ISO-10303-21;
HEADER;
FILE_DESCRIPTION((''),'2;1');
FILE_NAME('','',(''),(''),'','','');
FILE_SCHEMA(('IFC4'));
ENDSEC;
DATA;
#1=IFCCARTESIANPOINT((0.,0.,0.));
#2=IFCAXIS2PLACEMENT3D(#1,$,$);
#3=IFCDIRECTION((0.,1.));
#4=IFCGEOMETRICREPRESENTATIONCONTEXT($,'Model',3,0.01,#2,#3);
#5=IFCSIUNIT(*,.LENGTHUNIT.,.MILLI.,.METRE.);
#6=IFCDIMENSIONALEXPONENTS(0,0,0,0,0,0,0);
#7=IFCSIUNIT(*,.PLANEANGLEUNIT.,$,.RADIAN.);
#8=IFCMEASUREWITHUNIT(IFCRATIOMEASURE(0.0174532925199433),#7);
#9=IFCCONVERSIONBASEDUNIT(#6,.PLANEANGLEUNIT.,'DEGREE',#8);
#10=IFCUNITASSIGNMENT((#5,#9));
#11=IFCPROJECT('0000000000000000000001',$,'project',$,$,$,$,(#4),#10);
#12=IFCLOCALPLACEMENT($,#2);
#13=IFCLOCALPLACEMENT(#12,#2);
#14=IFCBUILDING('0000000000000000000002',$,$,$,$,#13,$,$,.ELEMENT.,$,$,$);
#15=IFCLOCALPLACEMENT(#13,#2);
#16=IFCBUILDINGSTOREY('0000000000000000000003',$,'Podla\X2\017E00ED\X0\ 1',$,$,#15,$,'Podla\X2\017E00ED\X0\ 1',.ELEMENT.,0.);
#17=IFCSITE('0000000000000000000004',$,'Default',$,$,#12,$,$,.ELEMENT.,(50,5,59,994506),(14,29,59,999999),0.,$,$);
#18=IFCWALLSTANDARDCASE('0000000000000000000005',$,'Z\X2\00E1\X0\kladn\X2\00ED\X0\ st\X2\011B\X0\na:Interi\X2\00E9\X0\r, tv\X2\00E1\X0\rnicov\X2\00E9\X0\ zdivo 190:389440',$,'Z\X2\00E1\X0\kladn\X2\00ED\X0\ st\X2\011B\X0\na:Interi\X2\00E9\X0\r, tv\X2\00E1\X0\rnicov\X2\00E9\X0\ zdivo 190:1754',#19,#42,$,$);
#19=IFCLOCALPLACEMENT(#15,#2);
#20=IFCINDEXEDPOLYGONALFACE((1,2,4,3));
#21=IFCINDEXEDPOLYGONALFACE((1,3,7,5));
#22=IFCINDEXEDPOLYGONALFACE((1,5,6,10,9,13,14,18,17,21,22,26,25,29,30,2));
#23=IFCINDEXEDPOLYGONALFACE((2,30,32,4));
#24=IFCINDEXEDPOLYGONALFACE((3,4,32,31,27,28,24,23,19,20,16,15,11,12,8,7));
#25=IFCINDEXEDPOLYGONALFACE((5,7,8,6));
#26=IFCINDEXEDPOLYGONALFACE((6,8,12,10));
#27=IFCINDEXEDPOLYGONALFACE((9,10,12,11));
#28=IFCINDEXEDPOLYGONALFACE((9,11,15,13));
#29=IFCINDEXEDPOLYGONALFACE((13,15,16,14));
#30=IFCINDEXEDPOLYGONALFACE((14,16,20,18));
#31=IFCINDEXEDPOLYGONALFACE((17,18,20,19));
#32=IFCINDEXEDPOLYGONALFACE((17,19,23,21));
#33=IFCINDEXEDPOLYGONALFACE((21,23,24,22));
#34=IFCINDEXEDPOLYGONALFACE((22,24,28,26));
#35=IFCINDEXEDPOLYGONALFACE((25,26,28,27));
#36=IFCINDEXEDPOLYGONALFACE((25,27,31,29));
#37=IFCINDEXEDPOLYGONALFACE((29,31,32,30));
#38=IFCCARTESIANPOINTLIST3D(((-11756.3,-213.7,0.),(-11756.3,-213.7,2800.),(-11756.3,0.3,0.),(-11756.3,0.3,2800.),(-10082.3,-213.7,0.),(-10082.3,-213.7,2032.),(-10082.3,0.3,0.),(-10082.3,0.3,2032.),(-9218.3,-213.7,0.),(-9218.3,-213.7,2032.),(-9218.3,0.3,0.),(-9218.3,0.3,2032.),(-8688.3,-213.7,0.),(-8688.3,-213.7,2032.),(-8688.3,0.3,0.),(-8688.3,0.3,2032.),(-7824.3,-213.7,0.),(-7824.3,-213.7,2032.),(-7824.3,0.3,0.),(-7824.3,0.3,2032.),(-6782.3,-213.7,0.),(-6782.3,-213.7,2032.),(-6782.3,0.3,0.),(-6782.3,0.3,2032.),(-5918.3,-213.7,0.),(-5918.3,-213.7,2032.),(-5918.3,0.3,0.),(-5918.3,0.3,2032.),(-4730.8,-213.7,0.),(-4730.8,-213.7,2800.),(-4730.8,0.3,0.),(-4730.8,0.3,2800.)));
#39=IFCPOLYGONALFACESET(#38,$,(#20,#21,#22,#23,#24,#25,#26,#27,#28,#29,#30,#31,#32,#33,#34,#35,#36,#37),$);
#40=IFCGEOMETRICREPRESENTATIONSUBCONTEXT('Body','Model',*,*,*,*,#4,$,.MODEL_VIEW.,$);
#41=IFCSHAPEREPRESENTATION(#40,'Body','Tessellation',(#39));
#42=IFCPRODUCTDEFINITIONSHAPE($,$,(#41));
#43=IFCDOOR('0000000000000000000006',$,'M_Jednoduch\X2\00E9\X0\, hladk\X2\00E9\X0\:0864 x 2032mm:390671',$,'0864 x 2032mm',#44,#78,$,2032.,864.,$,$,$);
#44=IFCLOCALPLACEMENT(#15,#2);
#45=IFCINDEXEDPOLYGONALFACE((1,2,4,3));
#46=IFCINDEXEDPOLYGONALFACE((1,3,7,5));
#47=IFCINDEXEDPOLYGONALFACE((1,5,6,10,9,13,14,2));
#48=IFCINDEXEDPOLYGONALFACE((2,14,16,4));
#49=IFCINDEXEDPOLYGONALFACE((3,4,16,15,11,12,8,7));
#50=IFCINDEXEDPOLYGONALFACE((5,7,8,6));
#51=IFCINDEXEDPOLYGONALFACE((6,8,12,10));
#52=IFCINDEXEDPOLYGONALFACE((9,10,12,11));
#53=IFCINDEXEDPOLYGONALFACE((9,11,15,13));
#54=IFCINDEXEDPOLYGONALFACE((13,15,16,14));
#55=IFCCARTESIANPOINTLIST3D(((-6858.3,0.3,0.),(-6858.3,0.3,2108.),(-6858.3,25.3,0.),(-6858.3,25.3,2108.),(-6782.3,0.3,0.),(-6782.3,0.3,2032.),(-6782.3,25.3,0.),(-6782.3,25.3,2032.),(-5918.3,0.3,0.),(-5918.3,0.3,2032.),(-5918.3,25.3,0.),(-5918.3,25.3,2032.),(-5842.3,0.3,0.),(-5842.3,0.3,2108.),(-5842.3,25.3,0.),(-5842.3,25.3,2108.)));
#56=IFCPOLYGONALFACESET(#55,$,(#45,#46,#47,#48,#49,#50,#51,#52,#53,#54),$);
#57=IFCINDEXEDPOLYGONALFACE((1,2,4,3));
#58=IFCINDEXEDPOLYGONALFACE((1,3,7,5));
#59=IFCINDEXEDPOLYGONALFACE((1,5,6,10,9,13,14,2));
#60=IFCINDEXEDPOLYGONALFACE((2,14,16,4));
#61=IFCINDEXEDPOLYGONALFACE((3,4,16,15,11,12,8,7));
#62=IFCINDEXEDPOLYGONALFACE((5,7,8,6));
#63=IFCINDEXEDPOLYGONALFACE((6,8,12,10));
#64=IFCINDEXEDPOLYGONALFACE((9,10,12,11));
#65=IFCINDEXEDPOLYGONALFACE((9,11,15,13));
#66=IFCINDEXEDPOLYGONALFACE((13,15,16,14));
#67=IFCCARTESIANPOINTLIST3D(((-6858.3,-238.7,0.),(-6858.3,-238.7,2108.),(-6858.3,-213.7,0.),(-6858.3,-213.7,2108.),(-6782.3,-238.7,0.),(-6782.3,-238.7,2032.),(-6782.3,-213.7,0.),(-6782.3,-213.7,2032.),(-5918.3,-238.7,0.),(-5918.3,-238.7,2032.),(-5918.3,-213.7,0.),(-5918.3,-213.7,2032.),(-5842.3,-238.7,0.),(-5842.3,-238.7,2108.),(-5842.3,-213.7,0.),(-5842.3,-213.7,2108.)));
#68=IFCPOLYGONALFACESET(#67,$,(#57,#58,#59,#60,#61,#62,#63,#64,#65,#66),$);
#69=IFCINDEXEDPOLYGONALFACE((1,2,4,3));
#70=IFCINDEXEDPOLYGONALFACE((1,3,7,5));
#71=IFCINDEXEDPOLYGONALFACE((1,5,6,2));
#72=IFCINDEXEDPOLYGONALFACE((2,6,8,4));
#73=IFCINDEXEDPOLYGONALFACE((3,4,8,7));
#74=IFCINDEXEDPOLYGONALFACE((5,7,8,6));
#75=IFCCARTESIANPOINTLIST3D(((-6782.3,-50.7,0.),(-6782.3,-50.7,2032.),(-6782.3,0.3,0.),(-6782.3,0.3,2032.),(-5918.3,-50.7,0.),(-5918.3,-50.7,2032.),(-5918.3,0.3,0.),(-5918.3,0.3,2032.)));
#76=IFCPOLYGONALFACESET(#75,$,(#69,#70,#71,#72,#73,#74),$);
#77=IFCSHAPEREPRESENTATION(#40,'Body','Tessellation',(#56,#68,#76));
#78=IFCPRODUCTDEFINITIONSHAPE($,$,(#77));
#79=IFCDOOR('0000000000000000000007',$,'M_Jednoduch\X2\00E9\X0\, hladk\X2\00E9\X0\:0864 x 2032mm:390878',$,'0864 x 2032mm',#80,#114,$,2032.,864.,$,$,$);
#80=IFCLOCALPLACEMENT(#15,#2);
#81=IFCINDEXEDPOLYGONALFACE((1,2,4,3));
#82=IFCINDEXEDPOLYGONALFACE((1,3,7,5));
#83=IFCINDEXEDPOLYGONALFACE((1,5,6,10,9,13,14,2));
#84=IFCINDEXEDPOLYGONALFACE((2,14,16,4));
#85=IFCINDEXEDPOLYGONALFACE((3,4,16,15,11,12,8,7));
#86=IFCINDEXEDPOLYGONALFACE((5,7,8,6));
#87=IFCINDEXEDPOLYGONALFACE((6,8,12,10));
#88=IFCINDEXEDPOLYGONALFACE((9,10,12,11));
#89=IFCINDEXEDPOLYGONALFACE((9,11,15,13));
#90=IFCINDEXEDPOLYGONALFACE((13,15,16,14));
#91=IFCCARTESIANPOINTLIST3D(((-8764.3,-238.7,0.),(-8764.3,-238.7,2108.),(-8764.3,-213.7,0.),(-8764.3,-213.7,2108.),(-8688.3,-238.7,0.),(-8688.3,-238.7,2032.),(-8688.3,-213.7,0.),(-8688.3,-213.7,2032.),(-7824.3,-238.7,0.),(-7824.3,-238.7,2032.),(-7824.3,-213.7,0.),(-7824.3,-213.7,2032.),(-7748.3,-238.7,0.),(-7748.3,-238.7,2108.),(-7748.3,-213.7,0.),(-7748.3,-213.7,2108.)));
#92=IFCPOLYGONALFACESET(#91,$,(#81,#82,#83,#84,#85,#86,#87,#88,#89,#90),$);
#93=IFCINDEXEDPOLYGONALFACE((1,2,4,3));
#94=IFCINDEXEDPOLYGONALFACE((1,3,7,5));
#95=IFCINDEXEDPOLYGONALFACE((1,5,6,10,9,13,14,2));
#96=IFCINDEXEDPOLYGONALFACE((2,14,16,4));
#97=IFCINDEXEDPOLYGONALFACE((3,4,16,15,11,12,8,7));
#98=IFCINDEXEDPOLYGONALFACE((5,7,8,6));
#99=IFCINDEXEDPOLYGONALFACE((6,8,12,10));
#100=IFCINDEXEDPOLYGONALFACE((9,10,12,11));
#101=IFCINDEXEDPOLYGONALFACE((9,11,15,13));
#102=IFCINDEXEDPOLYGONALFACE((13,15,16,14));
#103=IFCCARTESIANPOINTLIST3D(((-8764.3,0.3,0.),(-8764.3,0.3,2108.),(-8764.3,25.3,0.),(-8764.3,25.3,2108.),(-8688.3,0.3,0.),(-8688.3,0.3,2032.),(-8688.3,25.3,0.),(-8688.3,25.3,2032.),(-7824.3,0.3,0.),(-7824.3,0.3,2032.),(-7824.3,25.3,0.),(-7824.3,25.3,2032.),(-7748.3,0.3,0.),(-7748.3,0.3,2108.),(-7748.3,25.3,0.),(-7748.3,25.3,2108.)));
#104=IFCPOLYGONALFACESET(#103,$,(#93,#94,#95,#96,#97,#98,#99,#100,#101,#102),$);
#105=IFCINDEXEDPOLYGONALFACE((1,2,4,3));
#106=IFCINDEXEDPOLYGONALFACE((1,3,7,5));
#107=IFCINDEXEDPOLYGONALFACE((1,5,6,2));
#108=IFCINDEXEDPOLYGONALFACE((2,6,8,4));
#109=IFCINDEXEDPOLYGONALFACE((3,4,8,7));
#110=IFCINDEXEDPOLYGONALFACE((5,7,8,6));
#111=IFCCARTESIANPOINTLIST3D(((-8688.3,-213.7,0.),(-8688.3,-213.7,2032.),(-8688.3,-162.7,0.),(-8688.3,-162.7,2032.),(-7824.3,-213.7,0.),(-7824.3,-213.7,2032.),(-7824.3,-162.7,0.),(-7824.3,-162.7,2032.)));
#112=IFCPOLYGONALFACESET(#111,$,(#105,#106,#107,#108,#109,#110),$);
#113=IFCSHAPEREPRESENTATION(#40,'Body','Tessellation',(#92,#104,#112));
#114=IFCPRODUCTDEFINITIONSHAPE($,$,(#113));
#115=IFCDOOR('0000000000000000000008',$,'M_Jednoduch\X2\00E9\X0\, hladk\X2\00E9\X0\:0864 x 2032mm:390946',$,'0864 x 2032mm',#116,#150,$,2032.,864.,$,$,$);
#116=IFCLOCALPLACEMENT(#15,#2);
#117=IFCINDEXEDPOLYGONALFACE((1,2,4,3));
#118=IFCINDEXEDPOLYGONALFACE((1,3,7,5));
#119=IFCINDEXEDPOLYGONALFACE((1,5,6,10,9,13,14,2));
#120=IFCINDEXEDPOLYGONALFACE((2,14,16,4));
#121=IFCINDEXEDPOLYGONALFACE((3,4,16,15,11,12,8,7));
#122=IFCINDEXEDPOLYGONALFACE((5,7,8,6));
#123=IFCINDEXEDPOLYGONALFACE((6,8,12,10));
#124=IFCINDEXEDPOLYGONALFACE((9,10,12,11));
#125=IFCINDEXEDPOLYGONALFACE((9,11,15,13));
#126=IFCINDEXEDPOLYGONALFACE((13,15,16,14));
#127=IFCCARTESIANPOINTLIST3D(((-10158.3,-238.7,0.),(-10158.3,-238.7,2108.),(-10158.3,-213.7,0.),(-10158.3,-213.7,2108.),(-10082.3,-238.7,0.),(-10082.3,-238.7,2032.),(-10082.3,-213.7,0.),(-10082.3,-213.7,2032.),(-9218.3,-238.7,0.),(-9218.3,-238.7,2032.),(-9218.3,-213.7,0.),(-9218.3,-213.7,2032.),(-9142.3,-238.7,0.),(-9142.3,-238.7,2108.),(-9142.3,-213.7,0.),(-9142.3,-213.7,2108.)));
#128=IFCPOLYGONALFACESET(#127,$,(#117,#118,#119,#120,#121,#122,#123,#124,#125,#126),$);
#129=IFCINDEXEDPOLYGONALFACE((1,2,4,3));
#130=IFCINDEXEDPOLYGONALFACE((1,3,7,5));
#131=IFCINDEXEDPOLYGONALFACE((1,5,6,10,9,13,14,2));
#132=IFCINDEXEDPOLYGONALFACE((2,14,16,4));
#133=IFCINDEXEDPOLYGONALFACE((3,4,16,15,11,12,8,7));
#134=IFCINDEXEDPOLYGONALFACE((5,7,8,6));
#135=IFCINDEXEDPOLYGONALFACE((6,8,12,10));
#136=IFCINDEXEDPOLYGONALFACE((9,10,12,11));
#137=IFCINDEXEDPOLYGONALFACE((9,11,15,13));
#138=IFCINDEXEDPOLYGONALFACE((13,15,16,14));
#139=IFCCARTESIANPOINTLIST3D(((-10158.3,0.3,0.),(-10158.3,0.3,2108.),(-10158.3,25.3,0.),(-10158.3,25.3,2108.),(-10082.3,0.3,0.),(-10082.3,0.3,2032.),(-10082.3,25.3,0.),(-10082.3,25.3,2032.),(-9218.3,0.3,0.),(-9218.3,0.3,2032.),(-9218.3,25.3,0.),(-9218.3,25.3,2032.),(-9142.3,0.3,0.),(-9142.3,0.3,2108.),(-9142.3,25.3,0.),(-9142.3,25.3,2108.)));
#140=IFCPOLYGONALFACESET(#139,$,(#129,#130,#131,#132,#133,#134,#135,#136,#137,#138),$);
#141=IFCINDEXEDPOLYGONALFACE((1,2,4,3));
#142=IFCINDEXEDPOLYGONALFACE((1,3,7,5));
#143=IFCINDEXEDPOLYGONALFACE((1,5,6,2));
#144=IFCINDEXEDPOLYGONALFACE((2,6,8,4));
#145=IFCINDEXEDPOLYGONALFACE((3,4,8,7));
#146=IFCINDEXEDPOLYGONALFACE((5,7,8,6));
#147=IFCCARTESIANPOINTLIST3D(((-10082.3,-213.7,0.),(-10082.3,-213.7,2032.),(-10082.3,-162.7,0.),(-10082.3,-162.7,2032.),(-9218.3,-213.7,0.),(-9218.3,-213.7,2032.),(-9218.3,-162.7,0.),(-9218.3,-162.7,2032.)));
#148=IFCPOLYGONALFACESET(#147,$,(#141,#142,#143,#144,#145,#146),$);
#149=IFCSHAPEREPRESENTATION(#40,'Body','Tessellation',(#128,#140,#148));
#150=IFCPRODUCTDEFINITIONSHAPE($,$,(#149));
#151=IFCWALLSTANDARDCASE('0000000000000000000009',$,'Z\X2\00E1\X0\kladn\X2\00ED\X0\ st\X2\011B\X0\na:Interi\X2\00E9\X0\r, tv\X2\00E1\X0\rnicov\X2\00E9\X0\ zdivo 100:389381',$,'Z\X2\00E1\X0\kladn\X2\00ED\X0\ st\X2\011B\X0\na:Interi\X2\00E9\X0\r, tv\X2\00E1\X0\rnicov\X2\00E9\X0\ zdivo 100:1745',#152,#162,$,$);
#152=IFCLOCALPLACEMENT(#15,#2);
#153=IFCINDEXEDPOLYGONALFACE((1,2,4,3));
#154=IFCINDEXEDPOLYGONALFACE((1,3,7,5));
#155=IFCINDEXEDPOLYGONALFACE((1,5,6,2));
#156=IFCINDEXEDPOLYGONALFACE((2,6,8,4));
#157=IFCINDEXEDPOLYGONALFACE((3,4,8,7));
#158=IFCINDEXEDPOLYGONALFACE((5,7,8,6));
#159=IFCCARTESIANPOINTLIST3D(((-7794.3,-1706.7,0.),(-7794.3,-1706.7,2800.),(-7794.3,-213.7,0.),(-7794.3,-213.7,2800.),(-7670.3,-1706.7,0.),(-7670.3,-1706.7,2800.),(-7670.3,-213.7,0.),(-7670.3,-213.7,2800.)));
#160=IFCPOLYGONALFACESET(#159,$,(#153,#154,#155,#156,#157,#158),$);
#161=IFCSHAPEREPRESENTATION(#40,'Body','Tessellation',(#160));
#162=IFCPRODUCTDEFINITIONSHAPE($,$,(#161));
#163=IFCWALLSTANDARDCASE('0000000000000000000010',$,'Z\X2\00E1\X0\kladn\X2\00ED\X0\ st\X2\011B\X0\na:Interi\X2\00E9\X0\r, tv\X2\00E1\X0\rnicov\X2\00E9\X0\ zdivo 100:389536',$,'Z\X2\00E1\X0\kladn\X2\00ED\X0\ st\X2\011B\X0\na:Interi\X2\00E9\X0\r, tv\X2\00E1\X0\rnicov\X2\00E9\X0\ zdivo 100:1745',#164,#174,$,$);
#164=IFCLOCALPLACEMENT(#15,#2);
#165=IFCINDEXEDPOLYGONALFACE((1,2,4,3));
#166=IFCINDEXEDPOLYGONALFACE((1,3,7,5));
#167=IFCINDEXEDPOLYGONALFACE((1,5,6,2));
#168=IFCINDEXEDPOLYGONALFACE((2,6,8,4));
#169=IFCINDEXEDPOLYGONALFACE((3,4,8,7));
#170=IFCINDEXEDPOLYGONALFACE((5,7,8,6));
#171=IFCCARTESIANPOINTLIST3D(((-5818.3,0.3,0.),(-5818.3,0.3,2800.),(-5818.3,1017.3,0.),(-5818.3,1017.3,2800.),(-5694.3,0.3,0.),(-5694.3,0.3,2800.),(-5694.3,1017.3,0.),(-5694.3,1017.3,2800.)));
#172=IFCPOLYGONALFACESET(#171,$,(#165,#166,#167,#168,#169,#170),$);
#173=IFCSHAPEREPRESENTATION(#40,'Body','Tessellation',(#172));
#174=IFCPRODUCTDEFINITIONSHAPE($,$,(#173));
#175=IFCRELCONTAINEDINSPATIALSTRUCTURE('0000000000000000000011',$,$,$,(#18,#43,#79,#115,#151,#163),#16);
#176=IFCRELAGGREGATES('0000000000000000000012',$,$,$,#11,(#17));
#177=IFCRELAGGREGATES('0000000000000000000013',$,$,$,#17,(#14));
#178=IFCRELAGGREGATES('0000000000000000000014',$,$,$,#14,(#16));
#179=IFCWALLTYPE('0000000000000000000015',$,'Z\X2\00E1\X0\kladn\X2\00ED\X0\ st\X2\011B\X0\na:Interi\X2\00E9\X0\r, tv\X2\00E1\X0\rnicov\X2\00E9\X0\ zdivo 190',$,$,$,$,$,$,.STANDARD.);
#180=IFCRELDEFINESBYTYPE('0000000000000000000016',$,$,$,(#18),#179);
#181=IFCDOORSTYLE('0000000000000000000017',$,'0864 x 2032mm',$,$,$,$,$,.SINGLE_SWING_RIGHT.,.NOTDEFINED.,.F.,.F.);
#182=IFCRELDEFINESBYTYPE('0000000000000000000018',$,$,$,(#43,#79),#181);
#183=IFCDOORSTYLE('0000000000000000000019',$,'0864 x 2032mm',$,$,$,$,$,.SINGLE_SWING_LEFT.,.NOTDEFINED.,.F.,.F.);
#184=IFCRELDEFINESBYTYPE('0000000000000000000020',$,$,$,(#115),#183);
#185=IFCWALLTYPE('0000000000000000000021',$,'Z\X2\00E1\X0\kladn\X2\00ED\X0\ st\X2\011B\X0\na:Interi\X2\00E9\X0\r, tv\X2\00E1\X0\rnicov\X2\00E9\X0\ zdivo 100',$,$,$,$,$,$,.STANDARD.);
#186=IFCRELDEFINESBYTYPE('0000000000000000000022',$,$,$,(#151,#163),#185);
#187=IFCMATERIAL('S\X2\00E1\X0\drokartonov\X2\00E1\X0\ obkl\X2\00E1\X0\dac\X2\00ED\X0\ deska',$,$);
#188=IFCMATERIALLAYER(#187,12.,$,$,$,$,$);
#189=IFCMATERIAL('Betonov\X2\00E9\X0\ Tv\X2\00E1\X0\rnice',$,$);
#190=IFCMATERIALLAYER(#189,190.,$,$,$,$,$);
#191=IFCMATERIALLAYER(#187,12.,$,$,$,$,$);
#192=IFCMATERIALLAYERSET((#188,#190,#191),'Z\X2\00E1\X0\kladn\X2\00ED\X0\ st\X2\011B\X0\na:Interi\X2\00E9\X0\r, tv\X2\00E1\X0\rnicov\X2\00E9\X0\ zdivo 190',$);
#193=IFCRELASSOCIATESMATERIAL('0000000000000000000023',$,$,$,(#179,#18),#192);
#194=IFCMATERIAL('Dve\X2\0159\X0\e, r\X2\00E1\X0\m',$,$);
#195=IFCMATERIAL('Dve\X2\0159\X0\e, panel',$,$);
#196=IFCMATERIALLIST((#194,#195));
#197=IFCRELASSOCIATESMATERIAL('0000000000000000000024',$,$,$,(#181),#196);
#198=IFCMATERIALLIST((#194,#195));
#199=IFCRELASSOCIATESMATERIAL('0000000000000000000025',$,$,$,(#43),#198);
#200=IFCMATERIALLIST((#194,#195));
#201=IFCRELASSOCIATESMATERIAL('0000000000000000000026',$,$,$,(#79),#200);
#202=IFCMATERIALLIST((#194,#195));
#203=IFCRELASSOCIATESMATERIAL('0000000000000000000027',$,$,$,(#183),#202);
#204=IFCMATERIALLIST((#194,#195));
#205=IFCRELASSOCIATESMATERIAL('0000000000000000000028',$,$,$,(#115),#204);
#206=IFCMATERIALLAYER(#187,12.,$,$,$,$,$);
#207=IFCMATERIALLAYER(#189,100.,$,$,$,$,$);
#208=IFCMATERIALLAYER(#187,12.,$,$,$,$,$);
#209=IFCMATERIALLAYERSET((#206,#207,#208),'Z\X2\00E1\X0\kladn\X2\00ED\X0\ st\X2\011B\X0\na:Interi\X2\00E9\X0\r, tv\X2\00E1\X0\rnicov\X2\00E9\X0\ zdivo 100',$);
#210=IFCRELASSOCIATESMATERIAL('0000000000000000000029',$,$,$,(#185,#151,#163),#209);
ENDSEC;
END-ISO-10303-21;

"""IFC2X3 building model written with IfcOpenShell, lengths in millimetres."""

from ifc_helpers import new_model, entity, si_unit, converted_unit, direction, frame, frame_2d, origin, place, context, subcontext, project, spatial, polyline, rectangle, outline, extrude, source, transform, mapped, material, material_list, layer, layer_set, layer_usage, type_object, type_shapes, element, fill, save


model = new_model("IFC2X3")

# Units and contexts
model_context = context("Model", 3, precision=0.01, world=origin(), true_north=direction((0.0, 1.0)))
body_context = subcontext(model_context, "Body", "Model", "MODEL_VIEW")
ifc_project = project(units=[si_unit("LENGTHUNIT", "METRE", prefix="MILLI"), converted_unit("PLANEANGLEUNIT", "DEGREE", entity("IfcRatioMeasure", 0.0174532925199433), si_unit("PLANEANGLEUNIT", "RADIAN"), dimensions=[0, 0, 0, 0, 0, 0, 0])], contexts=[model_context])

# Site, building, storey
site_placement = place(None, origin())
site = spatial("IfcSite", under=ifc_project, at=site_placement, Name="Default", CompositionType="ELEMENT", RefLatitude=(50, 5, 59, 994506), RefLongitude=(14, 29, 59, 999999), RefElevation=0.0)
building_placement = place(site_placement, origin())
building = spatial("IfcBuilding", under=site, at=building_placement, CompositionType="ELEMENT")
storey_placement = place(building_placement, origin())
storey = spatial("IfcBuildingStorey", under=building, at=storey_placement, Name="Podlaží 1", LongName="Podlaží 1", CompositionType="ELEMENT", Elevation=0.0)

# Shared definitions
ifc_material_1 = material(Name="Betonové Tvárnice")
ifc_material_2 = material(Name="Sádrokartonová obkládací deska")

# Wall, openings, doors
ifc_layer_1 = layer(ifc_material_2, 12.0)
ifc_layer_2 = layer(ifc_material_1, 190.0)
ifc_layer_3 = layer(ifc_material_2, 12.0)
ifc_layer_set_1 = layer_set([ifc_layer_1, ifc_layer_2, ifc_layer_3], Name="Základní stěna:Interiér, tvárnicové zdivo 190")
ifc_layer_usage_1 = layer_usage(ifc_layer_set_1, "AXIS2", "NEGATIVE", 107.0)
wall_type_1 = type_object("IfcWallType", Name="Základní stěna:Interiér, tvárnicové zdivo 190", PredefinedType="STANDARD", material=ifc_layer_set_1)
wall_1_placement = place(storey_placement, frame((-11756.3, -106.7, 0.0)))
wall_1 = element("IfcWallStandardCase", 1, at=wall_1_placement, inside=storey, type_object=wall_type_1, material=ifc_layer_usage_1, Name="Základní stěna:Interiér, tvárnicové zdivo 190:389440", ObjectType="Základní stěna:Interiér, tvárnicové zdivo 190:1754", context=body_context, shape_type="SweptSolid", body=[
    extrude(rectangle(XDim=7025.5, YDim=214.0, at=frame_2d((3512.8, 0.0), x_axis=(-1.0, 0.0))), origin(), (0.0, 0.0, 1.0), 2800.0),
])
opening_1_placement = place(wall_1_placement, frame((4974.0, -107.0, 0.0)))
opening_1 = element("IfcOpeningElement", 2, at=opening_1_placement, cuts=wall_1, ObjectType="Opening", context=body_context, shape_type="SweptSolid", body=[
    extrude(rectangle(XDim=864.0, YDim=2032.0, at=frame_2d((1016.0, 432.0), x_axis=(0.0, 1.0))), frame((0.0, 0.0, 0.0), z_axis=(0.0, 1.0, 0.0), x_axis=(0.0, 0.0, 1.0)), (0.0, 0.0, 1.0), 214.0),
])
opening_2_placement = place(wall_1_placement, frame((3932.0, 107.0, 0.0)))
opening_2 = element("IfcOpeningElement", 3, at=opening_2_placement, cuts=wall_1, ObjectType="Opening", context=body_context, shape_type="SweptSolid", body=[
    extrude(rectangle(XDim=864.0, YDim=2032.0, at=frame_2d((1016.0, 432.0), x_axis=(0.0, 1.0))), frame((0.0, 0.0, 0.0), z_axis=(0.0, -1.0, 0.0), x_axis=(0.0, 0.0, 1.0)), (0.0, 0.0, 1.0), 214.0),
])
opening_3_placement = place(wall_1_placement, frame((2538.0, 107.0, 0.0)))
opening_3 = element("IfcOpeningElement", 4, at=opening_3_placement, cuts=wall_1, ObjectType="Opening", context=body_context, shape_type="SweptSolid", body=[
    extrude(rectangle(XDim=864.0, YDim=2032.0, at=frame_2d((1016.0, 432.0), x_axis=(0.0, -1.0))), frame((0.0, 0.0, 0.0), z_axis=(0.0, -1.0, 0.0), x_axis=(0.0, 0.0, 1.0)), (0.0, 0.0, 1.0), 214.0),
])
ifc_material_3 = material(Name="Dveře, rám")
ifc_material_4 = material(Name="Dveře, panel")
ifc_material_list_1 = material_list([ifc_material_3, ifc_material_4])
ifc_material_list_2 = material_list([ifc_material_3, ifc_material_4])
door_style_1 = type_object("IfcDoorStyle", Name="0864 x 2032mm", ConstructionType="NOTDEFINED", OperationType="SINGLE_SWING_RIGHT", ParameterTakesPrecedence=False, Sizeable=False, material=ifc_material_list_2)
shared_shape_1 = source(origin(), body_context, "Body", "SweptSolid", [
    extrude(outline(polyline([(-508.0, -1073.0), (508.0, -1073.0), (508.0, 1035.0), (432.0, 1035.0), (432.0, -997.0), (-432.0, -997.0), (-432.0, 1035.0), (-508.0, 1035.0), (-508.0, -1073.0)])), frame((432.0, 214.0, 1035.0), z_axis=(0.0, 1.0, 0.0), x_axis=(1.0, 0.0, 0.0)), (0.0, 0.0, 1.0), 25.0),
    extrude(outline(polyline([(-1073.0, -508.0), (1035.0, -508.0), (1035.0, -432.0), (-997.0, -432.0), (-997.0, 432.0), (1035.0, 432.0), (1035.0, 508.0), (-1073.0, 508.0), (-1073.0, -508.0)])), frame((432.0, -25.0, 1035.0), z_axis=(0.0, 1.0, 0.0), x_axis=(0.0, 0.0, -1.0)), (0.0, 0.0, 1.0), 25.0),
    extrude(rectangle(XDim=51.0, YDim=864.0, at=frame_2d((0.0, 0.0), x_axis=(1.0, 0.0))), frame((432.0, 188.5, 0.0), z_axis=(0.0, 0.0, 1.0), x_axis=(0.0, 1.0, 0.0)), (0.0, 0.0, 1.0), 2032.0),
])
type_shapes(door_style_1, [shared_shape_1])
door_1_placement = place(opening_1_placement, origin())
door_1 = element("IfcDoor", 5, at=door_1_placement, inside=storey, type_object=door_style_1, material=ifc_material_list_1, Name="M_Jednoduché, hladké:0864 x 2032mm:390671", ObjectType="0864 x 2032mm", OverallHeight=2032.0, OverallWidth=864.0, context=body_context, shape_type="MappedRepresentation", body=[
    mapped(shared_shape_1, transform((0.0, 0.0, 0.0), scale=1.0)),
])
fill(opening_1, door_1)
ifc_material_list_3 = material_list([ifc_material_3, ifc_material_4])
door_2_placement = place(opening_2_placement, frame((0.0, 0.0, 0.0), z_axis=(0.0, 0.0, 1.0), x_axis=(-1.0, 0.0, 0.0)))
door_2 = element("IfcDoor", 6, at=door_2_placement, inside=storey, type_object=door_style_1, material=ifc_material_list_3, Name="M_Jednoduché, hladké:0864 x 2032mm:390878", ObjectType="0864 x 2032mm", OverallHeight=2032.0, OverallWidth=864.0, context=body_context, shape_type="MappedRepresentation", body=[
    mapped(shared_shape_1, transform((0.0, 0.0, 0.0), scale=1.0)),
])
fill(opening_2, door_2)
ifc_material_list_4 = material_list([ifc_material_3, ifc_material_4])
ifc_material_list_5 = material_list([ifc_material_3, ifc_material_4])
door_style_2 = type_object("IfcDoorStyle", Name="0864 x 2032mm", ConstructionType="NOTDEFINED", OperationType="SINGLE_SWING_LEFT", ParameterTakesPrecedence=False, Sizeable=False, material=ifc_material_list_5)
shared_shape_2 = source(origin(), body_context, "Body", "SweptSolid", [
    extrude(outline(polyline([(-508.0, -1073.0), (508.0, -1073.0), (508.0, 1035.0), (432.0, 1035.0), (432.0, -997.0), (-432.0, -997.0), (-432.0, 1035.0), (-508.0, 1035.0), (-508.0, -1073.0)])), frame((432.0, 239.0, 1035.0), z_axis=(0.0, -1.0, 0.0), x_axis=(-1.0, 0.0, 0.0)), (0.0, 0.0, 1.0), 25.0),
    extrude(outline(polyline([(-1073.0, -508.0), (1035.0, -508.0), (1035.0, -432.0), (-997.0, -432.0), (-997.0, 432.0), (1035.0, 432.0), (1035.0, 508.0), (-1073.0, 508.0), (-1073.0, -508.0)])), frame((432.0, 0.0, 1035.0), z_axis=(0.0, -1.0, 0.0), x_axis=(0.0, 0.0, -1.0)), (0.0, 0.0, 1.0), 25.0),
    extrude(rectangle(XDim=864.0, YDim=51.0, at=frame_2d((0.0, 0.0), x_axis=(1.0, 0.0))), frame((432.0, 188.5, 0.0)), (0.0, 0.0, 1.0), 2032.0),
])
type_shapes(door_style_2, [shared_shape_2])
door_3_placement = place(opening_3_placement, frame((0.0, 0.0, 0.0), z_axis=(0.0, 0.0, 1.0), x_axis=(-1.0, 0.0, 0.0)))
door_3 = element("IfcDoor", 7, at=door_3_placement, inside=storey, type_object=door_style_2, material=ifc_material_list_4, Name="M_Jednoduché, hladké:0864 x 2032mm:390946", ObjectType="0864 x 2032mm", OverallHeight=2032.0, OverallWidth=864.0, context=body_context, shape_type="MappedRepresentation", body=[
    mapped(shared_shape_2, transform((0.0, 0.0, 0.0), scale=1.0)),
])
fill(opening_3, door_3)

# Walls
ifc_layer_4 = layer(ifc_material_2, 12.0)
ifc_layer_5 = layer(ifc_material_1, 100.0)
ifc_layer_6 = layer(ifc_material_2, 12.0)
ifc_layer_set_2 = layer_set([ifc_layer_4, ifc_layer_5, ifc_layer_6], Name="Základní stěna:Interiér, tvárnicové zdivo 100")
ifc_layer_usage_2 = layer_usage(ifc_layer_set_2, "AXIS2", "NEGATIVE", 62.0)
wall_type_2 = type_object("IfcWallType", Name="Základní stěna:Interiér, tvárnicové zdivo 100", PredefinedType="STANDARD", material=ifc_layer_set_2)
wall_2_placement = place(storey_placement, frame((-7732.3, -1706.7, 0.0), z_axis=(0.0, 0.0, 1.0), x_axis=(0.0, 1.0, 0.0)))
element("IfcWallStandardCase", 8, at=wall_2_placement, inside=storey, type_object=wall_type_2, material=ifc_layer_usage_2, Name="Základní stěna:Interiér, tvárnicové zdivo 100:389381", ObjectType="Základní stěna:Interiér, tvárnicové zdivo 100:1745", context=body_context, shape_type="SweptSolid", body=[
    extrude(rectangle(XDim=1493.0, YDim=124.0, at=frame_2d((746.5, 0.0), x_axis=(-1.0, 0.0))), origin(), (0.0, 0.0, 1.0), 2800.0),
])
ifc_layer_usage_3 = layer_usage(ifc_layer_set_2, "AXIS2", "NEGATIVE", 62.0)
wall_3_placement = place(storey_placement, frame((-5756.3, 0.3, 0.0), z_axis=(0.0, 0.0, 1.0), x_axis=(0.0, 1.0, 0.0)))
element("IfcWallStandardCase", 9, at=wall_3_placement, inside=storey, type_object=wall_type_2, material=ifc_layer_usage_3, Name="Základní stěna:Interiér, tvárnicové zdivo 100:389536", ObjectType="Základní stěna:Interiér, tvárnicové zdivo 100:1745", context=body_context, shape_type="SweptSolid", body=[
    extrude(rectangle(XDim=1017.0, YDim=124.0, at=frame_2d((508.5, 0.0), x_axis=(-1.0, 0.0))), origin(), (0.0, 0.0, 1.0), 2800.0),
])

save(model, "model.ifc")
